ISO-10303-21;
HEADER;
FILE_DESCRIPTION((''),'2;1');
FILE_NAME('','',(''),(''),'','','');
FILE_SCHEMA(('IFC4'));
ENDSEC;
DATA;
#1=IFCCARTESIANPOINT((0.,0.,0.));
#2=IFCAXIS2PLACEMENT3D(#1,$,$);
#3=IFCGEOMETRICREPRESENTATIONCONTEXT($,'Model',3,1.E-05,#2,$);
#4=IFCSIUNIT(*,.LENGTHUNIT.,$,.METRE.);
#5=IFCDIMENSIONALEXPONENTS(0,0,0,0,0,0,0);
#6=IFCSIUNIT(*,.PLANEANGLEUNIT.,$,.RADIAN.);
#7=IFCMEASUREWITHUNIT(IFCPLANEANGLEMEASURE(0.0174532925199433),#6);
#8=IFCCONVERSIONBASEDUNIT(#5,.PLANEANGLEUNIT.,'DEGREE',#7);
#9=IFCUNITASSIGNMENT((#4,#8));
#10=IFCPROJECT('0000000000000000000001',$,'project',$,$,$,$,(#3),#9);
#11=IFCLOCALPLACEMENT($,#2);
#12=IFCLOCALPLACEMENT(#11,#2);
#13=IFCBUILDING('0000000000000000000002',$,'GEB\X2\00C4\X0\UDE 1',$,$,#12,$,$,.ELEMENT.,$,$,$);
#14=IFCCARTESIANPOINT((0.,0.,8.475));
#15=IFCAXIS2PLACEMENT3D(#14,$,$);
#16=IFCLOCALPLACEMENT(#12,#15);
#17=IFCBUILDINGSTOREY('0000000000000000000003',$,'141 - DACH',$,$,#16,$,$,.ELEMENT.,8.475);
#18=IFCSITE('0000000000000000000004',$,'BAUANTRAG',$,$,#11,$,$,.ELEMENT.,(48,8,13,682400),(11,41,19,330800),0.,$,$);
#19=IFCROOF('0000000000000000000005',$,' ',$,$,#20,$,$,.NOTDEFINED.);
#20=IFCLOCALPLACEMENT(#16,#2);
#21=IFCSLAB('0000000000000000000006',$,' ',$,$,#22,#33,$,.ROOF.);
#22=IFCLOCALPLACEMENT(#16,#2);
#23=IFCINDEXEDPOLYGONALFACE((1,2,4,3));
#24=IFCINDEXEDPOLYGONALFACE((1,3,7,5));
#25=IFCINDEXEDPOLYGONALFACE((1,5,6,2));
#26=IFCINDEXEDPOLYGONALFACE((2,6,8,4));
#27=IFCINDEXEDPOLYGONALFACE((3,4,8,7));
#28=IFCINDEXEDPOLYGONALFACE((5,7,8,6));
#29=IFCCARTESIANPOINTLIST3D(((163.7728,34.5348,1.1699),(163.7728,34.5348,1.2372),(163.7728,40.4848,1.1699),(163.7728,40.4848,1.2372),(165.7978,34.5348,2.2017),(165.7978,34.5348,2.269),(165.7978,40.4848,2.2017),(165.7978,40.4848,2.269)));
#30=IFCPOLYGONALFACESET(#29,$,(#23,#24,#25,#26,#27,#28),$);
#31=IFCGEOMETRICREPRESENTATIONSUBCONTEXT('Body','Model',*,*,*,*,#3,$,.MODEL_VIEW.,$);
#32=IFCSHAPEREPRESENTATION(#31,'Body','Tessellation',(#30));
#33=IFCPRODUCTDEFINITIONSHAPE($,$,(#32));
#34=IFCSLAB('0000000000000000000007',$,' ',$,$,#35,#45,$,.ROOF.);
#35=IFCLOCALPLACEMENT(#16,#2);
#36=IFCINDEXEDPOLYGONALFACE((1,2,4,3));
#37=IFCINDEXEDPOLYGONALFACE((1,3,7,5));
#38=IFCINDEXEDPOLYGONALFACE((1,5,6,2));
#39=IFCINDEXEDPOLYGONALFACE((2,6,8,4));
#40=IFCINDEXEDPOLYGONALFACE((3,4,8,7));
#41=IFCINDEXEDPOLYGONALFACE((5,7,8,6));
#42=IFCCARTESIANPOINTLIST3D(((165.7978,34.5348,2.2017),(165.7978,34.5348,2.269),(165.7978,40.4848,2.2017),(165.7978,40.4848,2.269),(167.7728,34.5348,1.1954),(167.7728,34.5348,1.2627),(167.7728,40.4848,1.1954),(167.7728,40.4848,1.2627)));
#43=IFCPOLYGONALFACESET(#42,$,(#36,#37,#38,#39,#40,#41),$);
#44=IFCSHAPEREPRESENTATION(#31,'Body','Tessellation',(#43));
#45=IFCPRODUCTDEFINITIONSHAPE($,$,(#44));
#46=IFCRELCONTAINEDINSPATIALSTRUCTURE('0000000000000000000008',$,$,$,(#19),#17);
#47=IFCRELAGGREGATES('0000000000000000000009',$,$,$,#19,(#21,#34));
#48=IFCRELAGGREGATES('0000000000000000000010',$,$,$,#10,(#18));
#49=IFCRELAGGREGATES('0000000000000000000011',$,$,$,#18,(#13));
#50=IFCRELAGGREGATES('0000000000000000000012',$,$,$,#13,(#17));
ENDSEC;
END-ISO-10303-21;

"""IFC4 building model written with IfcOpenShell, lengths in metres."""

from ifc_helpers import new_model, entity, si_unit, converted_unit, frame, origin, place, context, subcontext, project, spatial, indexed_curve, outline, extrude, element, aggregate, save


model = new_model("IFC4")

# Units and contexts
model_context = context("Model", 3, precision=1e-05, world=origin())
body_context = subcontext(model_context, "Body", "Model", "MODEL_VIEW")
ifc_project = project(units=[si_unit("LENGTHUNIT", "METRE"), converted_unit("PLANEANGLEUNIT", "DEGREE", entity("IfcPlaneAngleMeasure", 0.0174532925199433), si_unit("PLANEANGLEUNIT", "RADIAN"), dimensions=[0, 0, 0, 0, 0, 0, 0])], contexts=[model_context])

# Site, building, storey
site_placement = place(None, origin())
site = spatial("IfcSite", under=ifc_project, at=site_placement, Name="BAUANTRAG", CompositionType="ELEMENT", RefLatitude=(48, 8, 13, 682400), RefLongitude=(11, 41, 19, 330800), RefElevation=0.0)
building_placement = place(site_placement, origin())
building = spatial("IfcBuilding", under=site, at=building_placement, Name="GEBÄUDE 1", CompositionType="ELEMENT")
storey_placement = place(building_placement, frame((0.0, 0.0, 8.475)))
storey = spatial("IfcBuildingStorey", under=building, at=storey_placement, Name="141 - DACH", CompositionType="ELEMENT", Elevation=8.475)

# Roof, slabs
roof_placement = place(storey_placement, frame((0.0, 0.0, -8.475)))
roof = element("IfcRoof", 1, at=roof_placement, inside=storey, Name=" ", PredefinedType="NOTDEFINED")
slab_1_placement = place(roof_placement, frame((163.7728, 34.5348, 9.6449)))
slab_1 = element("IfcSlab", 2, at=slab_1_placement, Name=" ", PredefinedType="ROOF", context=body_context, shape_type="SweptSolid", body=[
    extrude(outline(indexed_curve([(-2.975, -1.1364), (2.975, -1.1364), (2.975, 1.1364), (-2.975, 1.1364), (-2.975, -1.1364)], self_intersect=False)), frame((1.0125, 2.975, 0.5159), z_axis=(-0.45399, 0.0, 0.891007), x_axis=(0.0, 1.0, 0.0)), (0.0, -0.45399, 0.891007), 0.0673),
])
slab_2_placement = place(roof_placement, frame((165.7978, 34.5348, 9.6704)))
slab_2 = element("IfcSlab", 3, at=slab_2_placement, Name=" ", PredefinedType="ROOF", context=body_context, shape_type="SweptSolid", body=[
    extrude(outline(indexed_curve([(-2.975, 1.1083), (-2.975, -1.1083), (2.975, -1.1083), (2.975, 1.1083), (-2.975, 1.1083)], self_intersect=False)), frame((0.9875, 2.975, 0.5032), z_axis=(0.45399, 0.0, 0.891007), x_axis=(0.0, -1.0, 0.0)), (0.0, -0.45399, 0.891007), 0.0673),
])
aggregate(roof, [slab_1, slab_2])

save(model, "model.ifc")
